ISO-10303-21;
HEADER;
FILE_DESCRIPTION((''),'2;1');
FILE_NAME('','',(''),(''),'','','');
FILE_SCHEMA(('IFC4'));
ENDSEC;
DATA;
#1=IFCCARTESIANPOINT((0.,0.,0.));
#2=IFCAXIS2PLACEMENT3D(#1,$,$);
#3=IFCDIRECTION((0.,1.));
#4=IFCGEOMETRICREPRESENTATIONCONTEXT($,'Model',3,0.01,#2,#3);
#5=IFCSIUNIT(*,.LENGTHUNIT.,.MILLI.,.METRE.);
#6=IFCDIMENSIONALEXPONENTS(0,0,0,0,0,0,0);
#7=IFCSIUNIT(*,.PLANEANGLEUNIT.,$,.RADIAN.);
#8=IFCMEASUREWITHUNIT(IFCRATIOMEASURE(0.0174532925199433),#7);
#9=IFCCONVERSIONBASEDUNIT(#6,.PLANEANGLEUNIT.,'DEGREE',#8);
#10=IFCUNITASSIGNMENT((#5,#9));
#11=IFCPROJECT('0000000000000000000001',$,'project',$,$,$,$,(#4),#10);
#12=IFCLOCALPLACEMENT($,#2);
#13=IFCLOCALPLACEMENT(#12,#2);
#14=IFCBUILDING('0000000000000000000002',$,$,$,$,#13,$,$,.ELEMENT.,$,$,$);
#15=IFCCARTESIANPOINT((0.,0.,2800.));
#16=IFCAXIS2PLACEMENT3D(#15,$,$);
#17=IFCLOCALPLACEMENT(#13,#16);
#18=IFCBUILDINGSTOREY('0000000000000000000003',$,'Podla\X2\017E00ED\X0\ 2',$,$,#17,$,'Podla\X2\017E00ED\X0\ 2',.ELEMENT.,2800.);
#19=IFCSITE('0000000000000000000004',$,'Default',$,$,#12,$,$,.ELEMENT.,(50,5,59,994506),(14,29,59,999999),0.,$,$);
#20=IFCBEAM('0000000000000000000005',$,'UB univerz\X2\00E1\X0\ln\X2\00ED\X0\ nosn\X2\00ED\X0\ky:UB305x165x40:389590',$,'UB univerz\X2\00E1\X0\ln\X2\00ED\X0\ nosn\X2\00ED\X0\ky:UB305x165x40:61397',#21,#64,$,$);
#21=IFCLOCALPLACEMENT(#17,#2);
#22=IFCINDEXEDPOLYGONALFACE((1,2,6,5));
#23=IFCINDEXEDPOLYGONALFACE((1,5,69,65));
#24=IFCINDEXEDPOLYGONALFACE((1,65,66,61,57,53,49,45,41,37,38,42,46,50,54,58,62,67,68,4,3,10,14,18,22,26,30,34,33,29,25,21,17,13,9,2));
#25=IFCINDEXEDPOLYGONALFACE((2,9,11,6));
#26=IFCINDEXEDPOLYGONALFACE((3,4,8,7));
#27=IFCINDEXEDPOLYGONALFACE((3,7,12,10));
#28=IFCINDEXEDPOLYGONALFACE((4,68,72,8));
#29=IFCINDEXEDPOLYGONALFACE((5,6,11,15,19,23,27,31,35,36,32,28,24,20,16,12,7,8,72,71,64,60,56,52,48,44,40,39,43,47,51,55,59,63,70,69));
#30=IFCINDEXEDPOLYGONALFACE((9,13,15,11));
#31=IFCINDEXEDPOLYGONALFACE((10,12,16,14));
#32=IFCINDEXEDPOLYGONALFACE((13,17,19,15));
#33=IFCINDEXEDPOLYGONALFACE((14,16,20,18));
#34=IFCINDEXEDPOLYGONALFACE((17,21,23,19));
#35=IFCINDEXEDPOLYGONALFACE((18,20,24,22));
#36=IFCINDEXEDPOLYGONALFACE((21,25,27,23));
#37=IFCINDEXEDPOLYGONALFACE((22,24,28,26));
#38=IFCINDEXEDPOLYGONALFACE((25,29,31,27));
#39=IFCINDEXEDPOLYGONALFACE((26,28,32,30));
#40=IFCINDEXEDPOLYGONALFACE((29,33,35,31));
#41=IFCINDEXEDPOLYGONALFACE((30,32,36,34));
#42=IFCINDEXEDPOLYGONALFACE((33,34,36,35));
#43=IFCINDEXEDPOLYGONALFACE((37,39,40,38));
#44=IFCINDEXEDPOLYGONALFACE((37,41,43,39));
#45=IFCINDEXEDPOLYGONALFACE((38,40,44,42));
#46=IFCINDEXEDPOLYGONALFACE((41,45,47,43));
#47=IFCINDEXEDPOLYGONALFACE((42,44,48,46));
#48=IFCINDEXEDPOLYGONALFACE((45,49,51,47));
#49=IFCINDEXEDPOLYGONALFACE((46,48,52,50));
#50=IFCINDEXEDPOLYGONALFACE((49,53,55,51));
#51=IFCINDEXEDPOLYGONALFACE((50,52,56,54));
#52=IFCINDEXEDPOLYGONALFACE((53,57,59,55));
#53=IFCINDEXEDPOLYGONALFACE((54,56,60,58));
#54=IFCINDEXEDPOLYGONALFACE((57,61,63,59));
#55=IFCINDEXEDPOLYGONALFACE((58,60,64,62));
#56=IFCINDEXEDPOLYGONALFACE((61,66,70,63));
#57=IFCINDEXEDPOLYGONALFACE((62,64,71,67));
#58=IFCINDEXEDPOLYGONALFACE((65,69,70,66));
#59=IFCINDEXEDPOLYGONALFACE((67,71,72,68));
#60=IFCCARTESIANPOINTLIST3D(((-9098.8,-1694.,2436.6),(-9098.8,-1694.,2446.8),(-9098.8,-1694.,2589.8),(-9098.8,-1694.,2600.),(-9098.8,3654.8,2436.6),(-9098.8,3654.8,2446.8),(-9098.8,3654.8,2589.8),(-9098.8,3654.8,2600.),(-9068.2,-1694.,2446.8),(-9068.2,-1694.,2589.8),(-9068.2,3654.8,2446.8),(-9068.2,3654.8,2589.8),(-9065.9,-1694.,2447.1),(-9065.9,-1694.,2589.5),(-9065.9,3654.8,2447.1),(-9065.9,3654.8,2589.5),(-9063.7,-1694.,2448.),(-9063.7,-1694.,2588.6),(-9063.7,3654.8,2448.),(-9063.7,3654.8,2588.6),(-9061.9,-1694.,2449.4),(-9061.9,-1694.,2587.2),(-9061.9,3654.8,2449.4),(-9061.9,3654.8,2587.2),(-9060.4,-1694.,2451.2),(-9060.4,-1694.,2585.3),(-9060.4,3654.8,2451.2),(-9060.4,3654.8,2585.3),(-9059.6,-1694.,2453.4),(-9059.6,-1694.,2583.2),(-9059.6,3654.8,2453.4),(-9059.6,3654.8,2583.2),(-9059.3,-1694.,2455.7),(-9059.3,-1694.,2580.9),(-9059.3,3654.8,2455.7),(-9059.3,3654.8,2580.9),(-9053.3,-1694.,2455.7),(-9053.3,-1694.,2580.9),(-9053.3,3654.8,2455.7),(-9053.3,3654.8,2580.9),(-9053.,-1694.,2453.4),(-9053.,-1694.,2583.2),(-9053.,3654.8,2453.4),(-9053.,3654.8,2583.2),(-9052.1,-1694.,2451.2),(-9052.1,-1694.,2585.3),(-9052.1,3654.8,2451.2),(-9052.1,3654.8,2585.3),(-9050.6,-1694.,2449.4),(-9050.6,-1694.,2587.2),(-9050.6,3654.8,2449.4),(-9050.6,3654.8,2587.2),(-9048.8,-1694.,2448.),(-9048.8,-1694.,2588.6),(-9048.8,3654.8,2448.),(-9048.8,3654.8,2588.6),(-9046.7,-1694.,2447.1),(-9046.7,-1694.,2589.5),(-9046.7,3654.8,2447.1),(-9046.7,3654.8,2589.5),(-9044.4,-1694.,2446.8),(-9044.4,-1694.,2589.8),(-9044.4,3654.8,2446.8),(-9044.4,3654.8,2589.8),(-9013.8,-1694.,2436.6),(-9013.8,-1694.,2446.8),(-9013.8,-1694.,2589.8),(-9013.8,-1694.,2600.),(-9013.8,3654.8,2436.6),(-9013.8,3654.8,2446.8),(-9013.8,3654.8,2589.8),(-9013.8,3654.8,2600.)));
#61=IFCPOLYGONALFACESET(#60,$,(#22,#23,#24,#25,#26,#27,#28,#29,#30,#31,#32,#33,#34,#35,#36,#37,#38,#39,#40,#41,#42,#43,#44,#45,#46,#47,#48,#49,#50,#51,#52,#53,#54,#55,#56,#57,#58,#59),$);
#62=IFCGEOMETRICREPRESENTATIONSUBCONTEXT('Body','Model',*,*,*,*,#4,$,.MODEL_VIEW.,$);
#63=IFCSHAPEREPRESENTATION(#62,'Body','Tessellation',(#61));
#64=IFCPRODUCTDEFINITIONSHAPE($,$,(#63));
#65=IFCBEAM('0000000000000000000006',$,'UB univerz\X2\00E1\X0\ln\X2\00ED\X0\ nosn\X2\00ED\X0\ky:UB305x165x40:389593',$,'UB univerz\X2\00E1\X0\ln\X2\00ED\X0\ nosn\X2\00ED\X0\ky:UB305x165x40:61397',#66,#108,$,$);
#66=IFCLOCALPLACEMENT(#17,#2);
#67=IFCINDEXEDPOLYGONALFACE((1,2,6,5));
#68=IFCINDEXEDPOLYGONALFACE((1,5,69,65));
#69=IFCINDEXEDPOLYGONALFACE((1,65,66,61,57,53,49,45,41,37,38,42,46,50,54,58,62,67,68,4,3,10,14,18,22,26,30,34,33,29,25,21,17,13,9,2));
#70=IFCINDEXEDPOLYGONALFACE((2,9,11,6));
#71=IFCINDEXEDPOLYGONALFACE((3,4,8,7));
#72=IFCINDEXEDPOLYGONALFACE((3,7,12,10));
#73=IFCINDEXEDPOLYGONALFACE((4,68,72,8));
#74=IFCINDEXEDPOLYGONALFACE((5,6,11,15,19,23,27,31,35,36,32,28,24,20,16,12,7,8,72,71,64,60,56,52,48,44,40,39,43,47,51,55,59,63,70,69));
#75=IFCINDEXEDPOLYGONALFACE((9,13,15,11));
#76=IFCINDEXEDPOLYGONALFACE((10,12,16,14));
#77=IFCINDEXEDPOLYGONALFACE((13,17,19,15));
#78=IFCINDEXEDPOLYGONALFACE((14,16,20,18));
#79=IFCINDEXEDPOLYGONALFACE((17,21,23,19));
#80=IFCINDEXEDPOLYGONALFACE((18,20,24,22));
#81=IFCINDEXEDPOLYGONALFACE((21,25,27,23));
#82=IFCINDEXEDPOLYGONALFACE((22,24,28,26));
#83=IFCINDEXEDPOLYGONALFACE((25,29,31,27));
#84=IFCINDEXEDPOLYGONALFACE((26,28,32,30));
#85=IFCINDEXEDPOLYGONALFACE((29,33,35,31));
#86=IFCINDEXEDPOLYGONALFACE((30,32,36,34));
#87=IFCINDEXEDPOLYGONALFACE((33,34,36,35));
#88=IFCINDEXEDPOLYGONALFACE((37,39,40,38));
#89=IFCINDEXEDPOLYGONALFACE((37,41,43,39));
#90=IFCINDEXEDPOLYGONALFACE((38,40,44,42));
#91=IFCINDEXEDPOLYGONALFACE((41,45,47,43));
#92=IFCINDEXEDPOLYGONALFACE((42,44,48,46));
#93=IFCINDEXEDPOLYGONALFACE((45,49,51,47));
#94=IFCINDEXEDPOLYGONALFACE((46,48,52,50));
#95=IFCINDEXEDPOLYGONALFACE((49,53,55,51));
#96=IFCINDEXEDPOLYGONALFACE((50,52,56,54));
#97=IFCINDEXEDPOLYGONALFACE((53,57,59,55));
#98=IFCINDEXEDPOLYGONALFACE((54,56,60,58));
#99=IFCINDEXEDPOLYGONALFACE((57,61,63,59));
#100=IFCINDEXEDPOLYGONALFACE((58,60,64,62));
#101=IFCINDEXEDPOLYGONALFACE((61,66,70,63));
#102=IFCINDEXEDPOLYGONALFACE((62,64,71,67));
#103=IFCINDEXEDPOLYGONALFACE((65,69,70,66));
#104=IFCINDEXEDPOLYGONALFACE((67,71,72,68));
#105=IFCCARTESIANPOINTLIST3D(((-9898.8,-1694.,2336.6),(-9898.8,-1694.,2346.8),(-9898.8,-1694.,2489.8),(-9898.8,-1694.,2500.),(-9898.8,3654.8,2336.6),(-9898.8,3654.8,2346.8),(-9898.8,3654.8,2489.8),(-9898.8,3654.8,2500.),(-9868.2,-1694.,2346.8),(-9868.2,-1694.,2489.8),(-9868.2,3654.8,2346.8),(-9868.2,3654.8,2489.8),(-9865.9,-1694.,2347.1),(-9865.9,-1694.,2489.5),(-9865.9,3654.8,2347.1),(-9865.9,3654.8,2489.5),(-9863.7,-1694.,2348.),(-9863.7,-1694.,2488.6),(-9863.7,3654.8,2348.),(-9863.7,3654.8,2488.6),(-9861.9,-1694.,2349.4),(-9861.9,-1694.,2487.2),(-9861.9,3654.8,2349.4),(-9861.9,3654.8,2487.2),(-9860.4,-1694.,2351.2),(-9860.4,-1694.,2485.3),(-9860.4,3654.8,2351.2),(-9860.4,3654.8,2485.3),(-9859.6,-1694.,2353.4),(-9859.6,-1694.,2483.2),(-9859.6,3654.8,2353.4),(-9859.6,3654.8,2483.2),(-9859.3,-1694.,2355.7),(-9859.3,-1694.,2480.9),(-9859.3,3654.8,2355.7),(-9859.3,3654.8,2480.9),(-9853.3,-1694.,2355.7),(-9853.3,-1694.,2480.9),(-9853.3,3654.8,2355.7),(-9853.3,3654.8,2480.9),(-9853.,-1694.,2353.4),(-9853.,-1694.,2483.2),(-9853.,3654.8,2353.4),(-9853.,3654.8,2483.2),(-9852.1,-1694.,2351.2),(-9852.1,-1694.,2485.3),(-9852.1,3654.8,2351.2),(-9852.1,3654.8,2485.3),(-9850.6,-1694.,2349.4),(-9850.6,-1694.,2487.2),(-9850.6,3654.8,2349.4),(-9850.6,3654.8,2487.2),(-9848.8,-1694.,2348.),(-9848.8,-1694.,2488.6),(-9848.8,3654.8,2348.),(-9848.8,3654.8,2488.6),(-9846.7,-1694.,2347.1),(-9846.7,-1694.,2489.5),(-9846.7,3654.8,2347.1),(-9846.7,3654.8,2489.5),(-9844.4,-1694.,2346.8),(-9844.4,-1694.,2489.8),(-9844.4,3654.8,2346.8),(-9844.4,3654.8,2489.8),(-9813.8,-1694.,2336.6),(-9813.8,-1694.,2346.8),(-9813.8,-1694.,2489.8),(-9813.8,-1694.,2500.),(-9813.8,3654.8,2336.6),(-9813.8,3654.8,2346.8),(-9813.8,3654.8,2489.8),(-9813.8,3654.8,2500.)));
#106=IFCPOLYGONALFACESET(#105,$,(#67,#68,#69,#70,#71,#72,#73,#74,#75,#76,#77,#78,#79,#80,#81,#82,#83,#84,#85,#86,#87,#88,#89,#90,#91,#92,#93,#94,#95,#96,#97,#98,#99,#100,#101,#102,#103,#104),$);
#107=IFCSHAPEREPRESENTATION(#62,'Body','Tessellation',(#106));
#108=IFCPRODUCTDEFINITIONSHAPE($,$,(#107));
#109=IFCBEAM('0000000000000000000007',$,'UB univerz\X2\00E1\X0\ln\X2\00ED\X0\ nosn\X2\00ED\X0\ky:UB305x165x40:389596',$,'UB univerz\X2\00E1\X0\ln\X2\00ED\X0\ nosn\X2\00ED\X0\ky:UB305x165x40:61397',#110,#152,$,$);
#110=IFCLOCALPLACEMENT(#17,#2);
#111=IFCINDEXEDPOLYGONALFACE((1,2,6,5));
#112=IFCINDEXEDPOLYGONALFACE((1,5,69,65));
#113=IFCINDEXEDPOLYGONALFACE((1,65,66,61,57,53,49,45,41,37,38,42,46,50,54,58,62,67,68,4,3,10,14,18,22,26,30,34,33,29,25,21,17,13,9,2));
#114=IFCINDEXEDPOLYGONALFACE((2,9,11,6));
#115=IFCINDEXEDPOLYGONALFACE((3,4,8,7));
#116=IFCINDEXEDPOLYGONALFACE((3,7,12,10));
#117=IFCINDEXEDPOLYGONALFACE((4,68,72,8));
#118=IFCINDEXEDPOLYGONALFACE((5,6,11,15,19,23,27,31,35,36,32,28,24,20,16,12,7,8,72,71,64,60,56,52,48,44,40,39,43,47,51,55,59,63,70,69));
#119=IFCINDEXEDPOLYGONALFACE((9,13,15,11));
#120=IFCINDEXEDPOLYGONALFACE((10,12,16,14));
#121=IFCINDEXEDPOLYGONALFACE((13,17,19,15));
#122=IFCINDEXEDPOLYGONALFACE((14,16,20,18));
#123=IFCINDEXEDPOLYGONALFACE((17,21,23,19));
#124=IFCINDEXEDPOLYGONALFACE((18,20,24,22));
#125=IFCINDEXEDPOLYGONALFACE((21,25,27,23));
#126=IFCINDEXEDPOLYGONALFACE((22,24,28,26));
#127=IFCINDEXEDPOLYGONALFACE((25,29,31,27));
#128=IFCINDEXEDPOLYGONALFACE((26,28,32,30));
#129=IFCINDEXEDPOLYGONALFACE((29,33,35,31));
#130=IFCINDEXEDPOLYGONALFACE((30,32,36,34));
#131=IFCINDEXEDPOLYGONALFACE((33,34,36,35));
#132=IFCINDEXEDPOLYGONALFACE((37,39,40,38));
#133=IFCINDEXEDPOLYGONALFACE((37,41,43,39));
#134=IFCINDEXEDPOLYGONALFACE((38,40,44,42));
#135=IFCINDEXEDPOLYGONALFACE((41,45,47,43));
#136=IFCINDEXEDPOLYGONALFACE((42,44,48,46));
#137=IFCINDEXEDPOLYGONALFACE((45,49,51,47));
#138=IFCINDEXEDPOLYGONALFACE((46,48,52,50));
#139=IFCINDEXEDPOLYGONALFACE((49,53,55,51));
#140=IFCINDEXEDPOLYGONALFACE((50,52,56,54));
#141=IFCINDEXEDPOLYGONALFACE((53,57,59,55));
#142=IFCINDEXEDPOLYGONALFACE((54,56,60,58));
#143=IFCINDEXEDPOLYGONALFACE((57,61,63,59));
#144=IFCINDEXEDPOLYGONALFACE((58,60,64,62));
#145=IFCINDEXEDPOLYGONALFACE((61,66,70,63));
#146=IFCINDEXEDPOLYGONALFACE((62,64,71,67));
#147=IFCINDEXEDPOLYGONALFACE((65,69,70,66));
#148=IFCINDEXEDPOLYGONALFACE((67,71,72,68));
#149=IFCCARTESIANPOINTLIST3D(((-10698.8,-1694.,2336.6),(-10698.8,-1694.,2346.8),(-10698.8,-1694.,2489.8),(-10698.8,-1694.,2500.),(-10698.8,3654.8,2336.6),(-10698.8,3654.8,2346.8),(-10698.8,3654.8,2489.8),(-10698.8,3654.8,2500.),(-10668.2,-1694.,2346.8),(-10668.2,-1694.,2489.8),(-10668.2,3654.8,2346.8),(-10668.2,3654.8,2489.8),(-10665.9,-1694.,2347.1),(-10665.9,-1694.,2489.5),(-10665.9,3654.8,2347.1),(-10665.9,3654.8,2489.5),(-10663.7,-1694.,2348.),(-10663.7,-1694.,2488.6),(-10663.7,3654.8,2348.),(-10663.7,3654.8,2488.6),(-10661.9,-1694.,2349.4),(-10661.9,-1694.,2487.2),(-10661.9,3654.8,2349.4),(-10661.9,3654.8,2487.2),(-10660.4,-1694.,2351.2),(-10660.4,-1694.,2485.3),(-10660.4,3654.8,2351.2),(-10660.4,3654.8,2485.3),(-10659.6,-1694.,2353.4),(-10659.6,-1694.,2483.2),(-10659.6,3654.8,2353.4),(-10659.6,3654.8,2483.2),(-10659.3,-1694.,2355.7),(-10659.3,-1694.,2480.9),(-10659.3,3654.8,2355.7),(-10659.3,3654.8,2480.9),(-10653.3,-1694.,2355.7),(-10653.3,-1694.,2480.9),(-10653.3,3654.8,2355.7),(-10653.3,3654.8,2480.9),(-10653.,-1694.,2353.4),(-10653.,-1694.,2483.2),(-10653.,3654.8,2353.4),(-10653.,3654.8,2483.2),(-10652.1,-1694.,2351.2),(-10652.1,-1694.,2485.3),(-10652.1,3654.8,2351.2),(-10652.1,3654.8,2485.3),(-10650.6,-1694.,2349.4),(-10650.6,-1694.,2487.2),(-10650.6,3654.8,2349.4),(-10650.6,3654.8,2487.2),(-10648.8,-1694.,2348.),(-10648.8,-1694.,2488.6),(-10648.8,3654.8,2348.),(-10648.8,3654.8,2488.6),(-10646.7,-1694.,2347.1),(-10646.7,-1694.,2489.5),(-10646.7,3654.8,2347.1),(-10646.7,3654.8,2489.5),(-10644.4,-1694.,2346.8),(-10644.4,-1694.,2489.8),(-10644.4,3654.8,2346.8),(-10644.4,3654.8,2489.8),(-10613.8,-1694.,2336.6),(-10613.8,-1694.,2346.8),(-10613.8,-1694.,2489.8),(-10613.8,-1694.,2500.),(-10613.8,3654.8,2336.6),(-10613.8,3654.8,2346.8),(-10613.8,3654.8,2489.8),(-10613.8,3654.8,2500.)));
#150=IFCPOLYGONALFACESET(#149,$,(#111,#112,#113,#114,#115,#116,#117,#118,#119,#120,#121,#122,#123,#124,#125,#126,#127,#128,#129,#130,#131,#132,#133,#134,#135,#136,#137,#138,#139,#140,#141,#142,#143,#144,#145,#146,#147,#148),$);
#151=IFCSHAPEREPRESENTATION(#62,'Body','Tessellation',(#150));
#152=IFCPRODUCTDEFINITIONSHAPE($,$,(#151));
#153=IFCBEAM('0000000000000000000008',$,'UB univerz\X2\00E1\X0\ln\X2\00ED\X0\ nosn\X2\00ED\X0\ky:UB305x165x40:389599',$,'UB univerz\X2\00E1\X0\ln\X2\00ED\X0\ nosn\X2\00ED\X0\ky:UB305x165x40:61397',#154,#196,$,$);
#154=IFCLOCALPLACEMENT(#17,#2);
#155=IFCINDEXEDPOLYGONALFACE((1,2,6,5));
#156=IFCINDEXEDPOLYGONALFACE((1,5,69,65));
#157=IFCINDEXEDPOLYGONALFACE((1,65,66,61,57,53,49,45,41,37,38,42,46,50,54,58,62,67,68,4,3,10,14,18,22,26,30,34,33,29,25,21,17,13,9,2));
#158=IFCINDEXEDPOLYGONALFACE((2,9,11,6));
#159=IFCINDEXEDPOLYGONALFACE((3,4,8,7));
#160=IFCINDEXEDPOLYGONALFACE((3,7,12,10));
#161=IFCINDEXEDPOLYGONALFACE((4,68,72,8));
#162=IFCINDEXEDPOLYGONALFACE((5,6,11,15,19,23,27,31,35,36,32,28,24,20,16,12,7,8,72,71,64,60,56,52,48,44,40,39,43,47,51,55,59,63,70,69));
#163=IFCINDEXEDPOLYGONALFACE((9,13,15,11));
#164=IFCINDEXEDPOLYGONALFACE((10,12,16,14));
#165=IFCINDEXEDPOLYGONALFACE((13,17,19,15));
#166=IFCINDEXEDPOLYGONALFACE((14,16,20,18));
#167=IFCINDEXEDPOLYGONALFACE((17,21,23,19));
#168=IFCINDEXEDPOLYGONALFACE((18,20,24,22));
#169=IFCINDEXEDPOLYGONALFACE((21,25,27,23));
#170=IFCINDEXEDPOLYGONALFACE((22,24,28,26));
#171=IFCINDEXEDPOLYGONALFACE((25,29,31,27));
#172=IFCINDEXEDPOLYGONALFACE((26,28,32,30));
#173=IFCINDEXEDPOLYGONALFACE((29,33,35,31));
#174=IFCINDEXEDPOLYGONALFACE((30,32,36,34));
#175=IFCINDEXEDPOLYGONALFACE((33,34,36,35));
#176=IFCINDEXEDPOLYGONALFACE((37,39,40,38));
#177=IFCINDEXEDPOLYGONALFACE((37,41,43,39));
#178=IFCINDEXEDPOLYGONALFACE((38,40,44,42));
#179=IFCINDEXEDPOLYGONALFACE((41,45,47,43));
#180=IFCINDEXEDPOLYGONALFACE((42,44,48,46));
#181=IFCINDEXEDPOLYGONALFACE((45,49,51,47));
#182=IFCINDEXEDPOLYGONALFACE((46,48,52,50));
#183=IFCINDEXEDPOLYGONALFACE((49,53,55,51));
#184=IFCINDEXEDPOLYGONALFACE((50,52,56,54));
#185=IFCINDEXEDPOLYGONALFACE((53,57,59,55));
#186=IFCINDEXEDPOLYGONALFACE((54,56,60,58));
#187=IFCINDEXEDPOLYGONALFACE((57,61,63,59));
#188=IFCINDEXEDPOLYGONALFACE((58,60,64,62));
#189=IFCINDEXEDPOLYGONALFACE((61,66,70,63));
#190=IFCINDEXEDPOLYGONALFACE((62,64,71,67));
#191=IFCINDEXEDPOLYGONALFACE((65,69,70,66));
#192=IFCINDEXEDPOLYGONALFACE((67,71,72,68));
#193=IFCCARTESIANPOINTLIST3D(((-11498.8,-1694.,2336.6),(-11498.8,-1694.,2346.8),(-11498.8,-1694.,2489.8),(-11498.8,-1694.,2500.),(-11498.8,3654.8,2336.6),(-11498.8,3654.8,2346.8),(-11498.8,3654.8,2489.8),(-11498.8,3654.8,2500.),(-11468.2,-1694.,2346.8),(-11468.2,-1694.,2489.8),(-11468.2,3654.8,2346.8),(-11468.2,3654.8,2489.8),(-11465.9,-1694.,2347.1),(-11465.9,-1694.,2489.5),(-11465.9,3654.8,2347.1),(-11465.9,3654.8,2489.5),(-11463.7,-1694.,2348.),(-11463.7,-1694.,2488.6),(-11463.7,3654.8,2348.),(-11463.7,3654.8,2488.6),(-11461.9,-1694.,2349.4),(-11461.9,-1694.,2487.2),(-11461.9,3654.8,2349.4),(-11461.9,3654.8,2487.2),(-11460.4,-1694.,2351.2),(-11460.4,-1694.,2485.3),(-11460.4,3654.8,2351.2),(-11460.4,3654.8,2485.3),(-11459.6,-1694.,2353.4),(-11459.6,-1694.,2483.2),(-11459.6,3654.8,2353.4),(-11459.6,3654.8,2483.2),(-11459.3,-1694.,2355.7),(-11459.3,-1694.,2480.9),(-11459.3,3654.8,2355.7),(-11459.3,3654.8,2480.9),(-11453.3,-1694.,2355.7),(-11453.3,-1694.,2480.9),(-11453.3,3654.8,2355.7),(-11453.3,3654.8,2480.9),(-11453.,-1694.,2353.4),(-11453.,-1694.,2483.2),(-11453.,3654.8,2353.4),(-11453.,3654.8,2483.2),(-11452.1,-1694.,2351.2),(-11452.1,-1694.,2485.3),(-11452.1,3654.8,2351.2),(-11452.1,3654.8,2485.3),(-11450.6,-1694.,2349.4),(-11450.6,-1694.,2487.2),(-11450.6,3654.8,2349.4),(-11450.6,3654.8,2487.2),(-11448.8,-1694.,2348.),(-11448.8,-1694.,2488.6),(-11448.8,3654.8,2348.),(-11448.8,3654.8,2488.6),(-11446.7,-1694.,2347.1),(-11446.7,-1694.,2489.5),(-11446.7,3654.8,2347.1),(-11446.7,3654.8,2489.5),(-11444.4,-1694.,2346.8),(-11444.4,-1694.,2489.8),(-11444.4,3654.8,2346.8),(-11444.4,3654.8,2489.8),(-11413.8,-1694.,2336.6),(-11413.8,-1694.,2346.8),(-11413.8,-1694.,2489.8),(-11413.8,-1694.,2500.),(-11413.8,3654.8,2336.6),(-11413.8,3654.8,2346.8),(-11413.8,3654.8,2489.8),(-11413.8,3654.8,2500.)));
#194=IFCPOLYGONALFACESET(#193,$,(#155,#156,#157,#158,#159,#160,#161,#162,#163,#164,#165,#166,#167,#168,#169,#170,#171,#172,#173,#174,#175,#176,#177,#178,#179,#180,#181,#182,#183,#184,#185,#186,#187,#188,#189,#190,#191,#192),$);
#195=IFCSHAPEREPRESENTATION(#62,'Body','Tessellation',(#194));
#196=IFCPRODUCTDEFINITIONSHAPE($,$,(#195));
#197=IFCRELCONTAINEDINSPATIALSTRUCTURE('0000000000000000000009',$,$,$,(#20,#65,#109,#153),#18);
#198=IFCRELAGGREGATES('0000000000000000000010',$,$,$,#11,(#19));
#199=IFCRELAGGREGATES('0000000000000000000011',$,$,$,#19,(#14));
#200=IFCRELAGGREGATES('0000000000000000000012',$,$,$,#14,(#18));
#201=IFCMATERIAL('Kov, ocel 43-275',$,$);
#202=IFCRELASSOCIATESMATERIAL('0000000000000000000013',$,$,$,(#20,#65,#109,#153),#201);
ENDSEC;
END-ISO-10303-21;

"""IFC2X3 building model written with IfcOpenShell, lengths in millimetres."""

from ifc_helpers import new_model, entity, si_unit, converted_unit, direction, frame, frame_2d, origin, place, context, subcontext, project, spatial, i_section, extrude, material, element, save


model = new_model("IFC2X3")

# Units and contexts
model_context = context("Model", 3, precision=0.01, world=origin(), true_north=direction((0.0, 1.0)))
body_context = subcontext(model_context, "Body", "Model", "MODEL_VIEW")
ifc_project = project(units=[si_unit("LENGTHUNIT", "METRE", prefix="MILLI"), converted_unit("PLANEANGLEUNIT", "DEGREE", entity("IfcRatioMeasure", 0.0174532925199433), si_unit("PLANEANGLEUNIT", "RADIAN"), dimensions=[0, 0, 0, 0, 0, 0, 0])], contexts=[model_context])

# Site, building, storey
site_placement = place(None, origin())
site = spatial("IfcSite", under=ifc_project, at=site_placement, Name="Default", CompositionType="ELEMENT", RefLatitude=(50, 5, 59, 994506), RefLongitude=(14, 29, 59, 999999), RefElevation=0.0)
building_placement = place(site_placement, origin())
building = spatial("IfcBuilding", under=site, at=building_placement, CompositionType="ELEMENT")
storey_placement = place(building_placement, frame((0.0, 0.0, 2800.0)))
storey = spatial("IfcBuildingStorey", under=building, at=storey_placement, Name="Podlaží 2", LongName="Podlaží 2", CompositionType="ELEMENT", Elevation=2800.0)

# Beams
ifc_material = material(Name="Kov, ocel 43-275")
beam_1_placement = place(storey_placement, frame((-9056.3, 3654.8, 0.0), z_axis=(0.0, 0.0, 1.0), x_axis=(0.0, -1.0, 0.0)))
element("IfcBeam", 1, at=beam_1_placement, inside=storey, material=ifc_material, Name="UB univerzální nosníky:UB305x165x40:389590", ObjectType="UB univerzální nosníky:UB305x165x40:61397", context=body_context, shape_type="SweptSolid", body=[
    extrude(i_section(OverallWidth=85.0, OverallDepth=163.4, WebThickness=6.0, FlangeThickness=10.2, FilletRadius=8.9, at=frame_2d((0.0, 0.0), x_axis=(0.0, 1.0))), frame((0.0, 0.0, 2518.3), z_axis=(1.0, 0.0, 0.0), x_axis=(0.0, 0.0, -1.0)), (0.0, 0.0, 1.0), 5348.8),
])
beam_2_placement = place(storey_placement, frame((-9856.3, 3654.8, 0.0), z_axis=(0.0, 0.0, 1.0), x_axis=(0.0, -1.0, 0.0)))
element("IfcBeam", 2, at=beam_2_placement, inside=storey, material=ifc_material, Name="UB univerzální nosníky:UB305x165x40:389593", ObjectType="UB univerzální nosníky:UB305x165x40:61397", context=body_context, shape_type="SweptSolid", body=[
    extrude(i_section(OverallWidth=85.0, OverallDepth=163.4, WebThickness=6.0, FlangeThickness=10.2, FilletRadius=8.9, at=frame_2d((0.0, 0.0), x_axis=(0.0, 1.0))), frame((0.0, 0.0, 2418.3), z_axis=(1.0, 0.0, 0.0), x_axis=(0.0, 0.0, -1.0)), (0.0, 0.0, 1.0), 5348.8),
])
for number, where, z_axis, x_axis, name in (
    (3, (-10656.3, 3654.8, 0.0), (0.0, 0.0, 1.0), (0.0, -1.0, 0.0), "UB univerzální nosníky:UB305x165x40:389596"),
    (4, (-11456.3, 3654.8, 0.0), (0.0, 0.0, 1.0), (0.0, -1.0, 0.0), "UB univerzální nosníky:UB305x165x40:389599"),
):
    element("IfcBeam", number, at=place(storey_placement, frame(where, z_axis=z_axis, x_axis=x_axis)), inside=storey, material=ifc_material, Name=name, ObjectType="UB univerzální nosníky:UB305x165x40:61397", context=body_context, shape_type="SweptSolid", body=[
        extrude(i_section(OverallWidth=85.0, OverallDepth=163.4, WebThickness=6.0, FlangeThickness=10.2, FilletRadius=8.9, at=frame_2d((0.0, 0.0), x_axis=(0.0, 1.0))), frame((0.0, 0.0, 2418.3), z_axis=(1.0, 0.0, 0.0), x_axis=(0.0, 0.0, -1.0)), (0.0, 0.0, 1.0), 5348.8),
    ])

save(model, "model.ifc")
